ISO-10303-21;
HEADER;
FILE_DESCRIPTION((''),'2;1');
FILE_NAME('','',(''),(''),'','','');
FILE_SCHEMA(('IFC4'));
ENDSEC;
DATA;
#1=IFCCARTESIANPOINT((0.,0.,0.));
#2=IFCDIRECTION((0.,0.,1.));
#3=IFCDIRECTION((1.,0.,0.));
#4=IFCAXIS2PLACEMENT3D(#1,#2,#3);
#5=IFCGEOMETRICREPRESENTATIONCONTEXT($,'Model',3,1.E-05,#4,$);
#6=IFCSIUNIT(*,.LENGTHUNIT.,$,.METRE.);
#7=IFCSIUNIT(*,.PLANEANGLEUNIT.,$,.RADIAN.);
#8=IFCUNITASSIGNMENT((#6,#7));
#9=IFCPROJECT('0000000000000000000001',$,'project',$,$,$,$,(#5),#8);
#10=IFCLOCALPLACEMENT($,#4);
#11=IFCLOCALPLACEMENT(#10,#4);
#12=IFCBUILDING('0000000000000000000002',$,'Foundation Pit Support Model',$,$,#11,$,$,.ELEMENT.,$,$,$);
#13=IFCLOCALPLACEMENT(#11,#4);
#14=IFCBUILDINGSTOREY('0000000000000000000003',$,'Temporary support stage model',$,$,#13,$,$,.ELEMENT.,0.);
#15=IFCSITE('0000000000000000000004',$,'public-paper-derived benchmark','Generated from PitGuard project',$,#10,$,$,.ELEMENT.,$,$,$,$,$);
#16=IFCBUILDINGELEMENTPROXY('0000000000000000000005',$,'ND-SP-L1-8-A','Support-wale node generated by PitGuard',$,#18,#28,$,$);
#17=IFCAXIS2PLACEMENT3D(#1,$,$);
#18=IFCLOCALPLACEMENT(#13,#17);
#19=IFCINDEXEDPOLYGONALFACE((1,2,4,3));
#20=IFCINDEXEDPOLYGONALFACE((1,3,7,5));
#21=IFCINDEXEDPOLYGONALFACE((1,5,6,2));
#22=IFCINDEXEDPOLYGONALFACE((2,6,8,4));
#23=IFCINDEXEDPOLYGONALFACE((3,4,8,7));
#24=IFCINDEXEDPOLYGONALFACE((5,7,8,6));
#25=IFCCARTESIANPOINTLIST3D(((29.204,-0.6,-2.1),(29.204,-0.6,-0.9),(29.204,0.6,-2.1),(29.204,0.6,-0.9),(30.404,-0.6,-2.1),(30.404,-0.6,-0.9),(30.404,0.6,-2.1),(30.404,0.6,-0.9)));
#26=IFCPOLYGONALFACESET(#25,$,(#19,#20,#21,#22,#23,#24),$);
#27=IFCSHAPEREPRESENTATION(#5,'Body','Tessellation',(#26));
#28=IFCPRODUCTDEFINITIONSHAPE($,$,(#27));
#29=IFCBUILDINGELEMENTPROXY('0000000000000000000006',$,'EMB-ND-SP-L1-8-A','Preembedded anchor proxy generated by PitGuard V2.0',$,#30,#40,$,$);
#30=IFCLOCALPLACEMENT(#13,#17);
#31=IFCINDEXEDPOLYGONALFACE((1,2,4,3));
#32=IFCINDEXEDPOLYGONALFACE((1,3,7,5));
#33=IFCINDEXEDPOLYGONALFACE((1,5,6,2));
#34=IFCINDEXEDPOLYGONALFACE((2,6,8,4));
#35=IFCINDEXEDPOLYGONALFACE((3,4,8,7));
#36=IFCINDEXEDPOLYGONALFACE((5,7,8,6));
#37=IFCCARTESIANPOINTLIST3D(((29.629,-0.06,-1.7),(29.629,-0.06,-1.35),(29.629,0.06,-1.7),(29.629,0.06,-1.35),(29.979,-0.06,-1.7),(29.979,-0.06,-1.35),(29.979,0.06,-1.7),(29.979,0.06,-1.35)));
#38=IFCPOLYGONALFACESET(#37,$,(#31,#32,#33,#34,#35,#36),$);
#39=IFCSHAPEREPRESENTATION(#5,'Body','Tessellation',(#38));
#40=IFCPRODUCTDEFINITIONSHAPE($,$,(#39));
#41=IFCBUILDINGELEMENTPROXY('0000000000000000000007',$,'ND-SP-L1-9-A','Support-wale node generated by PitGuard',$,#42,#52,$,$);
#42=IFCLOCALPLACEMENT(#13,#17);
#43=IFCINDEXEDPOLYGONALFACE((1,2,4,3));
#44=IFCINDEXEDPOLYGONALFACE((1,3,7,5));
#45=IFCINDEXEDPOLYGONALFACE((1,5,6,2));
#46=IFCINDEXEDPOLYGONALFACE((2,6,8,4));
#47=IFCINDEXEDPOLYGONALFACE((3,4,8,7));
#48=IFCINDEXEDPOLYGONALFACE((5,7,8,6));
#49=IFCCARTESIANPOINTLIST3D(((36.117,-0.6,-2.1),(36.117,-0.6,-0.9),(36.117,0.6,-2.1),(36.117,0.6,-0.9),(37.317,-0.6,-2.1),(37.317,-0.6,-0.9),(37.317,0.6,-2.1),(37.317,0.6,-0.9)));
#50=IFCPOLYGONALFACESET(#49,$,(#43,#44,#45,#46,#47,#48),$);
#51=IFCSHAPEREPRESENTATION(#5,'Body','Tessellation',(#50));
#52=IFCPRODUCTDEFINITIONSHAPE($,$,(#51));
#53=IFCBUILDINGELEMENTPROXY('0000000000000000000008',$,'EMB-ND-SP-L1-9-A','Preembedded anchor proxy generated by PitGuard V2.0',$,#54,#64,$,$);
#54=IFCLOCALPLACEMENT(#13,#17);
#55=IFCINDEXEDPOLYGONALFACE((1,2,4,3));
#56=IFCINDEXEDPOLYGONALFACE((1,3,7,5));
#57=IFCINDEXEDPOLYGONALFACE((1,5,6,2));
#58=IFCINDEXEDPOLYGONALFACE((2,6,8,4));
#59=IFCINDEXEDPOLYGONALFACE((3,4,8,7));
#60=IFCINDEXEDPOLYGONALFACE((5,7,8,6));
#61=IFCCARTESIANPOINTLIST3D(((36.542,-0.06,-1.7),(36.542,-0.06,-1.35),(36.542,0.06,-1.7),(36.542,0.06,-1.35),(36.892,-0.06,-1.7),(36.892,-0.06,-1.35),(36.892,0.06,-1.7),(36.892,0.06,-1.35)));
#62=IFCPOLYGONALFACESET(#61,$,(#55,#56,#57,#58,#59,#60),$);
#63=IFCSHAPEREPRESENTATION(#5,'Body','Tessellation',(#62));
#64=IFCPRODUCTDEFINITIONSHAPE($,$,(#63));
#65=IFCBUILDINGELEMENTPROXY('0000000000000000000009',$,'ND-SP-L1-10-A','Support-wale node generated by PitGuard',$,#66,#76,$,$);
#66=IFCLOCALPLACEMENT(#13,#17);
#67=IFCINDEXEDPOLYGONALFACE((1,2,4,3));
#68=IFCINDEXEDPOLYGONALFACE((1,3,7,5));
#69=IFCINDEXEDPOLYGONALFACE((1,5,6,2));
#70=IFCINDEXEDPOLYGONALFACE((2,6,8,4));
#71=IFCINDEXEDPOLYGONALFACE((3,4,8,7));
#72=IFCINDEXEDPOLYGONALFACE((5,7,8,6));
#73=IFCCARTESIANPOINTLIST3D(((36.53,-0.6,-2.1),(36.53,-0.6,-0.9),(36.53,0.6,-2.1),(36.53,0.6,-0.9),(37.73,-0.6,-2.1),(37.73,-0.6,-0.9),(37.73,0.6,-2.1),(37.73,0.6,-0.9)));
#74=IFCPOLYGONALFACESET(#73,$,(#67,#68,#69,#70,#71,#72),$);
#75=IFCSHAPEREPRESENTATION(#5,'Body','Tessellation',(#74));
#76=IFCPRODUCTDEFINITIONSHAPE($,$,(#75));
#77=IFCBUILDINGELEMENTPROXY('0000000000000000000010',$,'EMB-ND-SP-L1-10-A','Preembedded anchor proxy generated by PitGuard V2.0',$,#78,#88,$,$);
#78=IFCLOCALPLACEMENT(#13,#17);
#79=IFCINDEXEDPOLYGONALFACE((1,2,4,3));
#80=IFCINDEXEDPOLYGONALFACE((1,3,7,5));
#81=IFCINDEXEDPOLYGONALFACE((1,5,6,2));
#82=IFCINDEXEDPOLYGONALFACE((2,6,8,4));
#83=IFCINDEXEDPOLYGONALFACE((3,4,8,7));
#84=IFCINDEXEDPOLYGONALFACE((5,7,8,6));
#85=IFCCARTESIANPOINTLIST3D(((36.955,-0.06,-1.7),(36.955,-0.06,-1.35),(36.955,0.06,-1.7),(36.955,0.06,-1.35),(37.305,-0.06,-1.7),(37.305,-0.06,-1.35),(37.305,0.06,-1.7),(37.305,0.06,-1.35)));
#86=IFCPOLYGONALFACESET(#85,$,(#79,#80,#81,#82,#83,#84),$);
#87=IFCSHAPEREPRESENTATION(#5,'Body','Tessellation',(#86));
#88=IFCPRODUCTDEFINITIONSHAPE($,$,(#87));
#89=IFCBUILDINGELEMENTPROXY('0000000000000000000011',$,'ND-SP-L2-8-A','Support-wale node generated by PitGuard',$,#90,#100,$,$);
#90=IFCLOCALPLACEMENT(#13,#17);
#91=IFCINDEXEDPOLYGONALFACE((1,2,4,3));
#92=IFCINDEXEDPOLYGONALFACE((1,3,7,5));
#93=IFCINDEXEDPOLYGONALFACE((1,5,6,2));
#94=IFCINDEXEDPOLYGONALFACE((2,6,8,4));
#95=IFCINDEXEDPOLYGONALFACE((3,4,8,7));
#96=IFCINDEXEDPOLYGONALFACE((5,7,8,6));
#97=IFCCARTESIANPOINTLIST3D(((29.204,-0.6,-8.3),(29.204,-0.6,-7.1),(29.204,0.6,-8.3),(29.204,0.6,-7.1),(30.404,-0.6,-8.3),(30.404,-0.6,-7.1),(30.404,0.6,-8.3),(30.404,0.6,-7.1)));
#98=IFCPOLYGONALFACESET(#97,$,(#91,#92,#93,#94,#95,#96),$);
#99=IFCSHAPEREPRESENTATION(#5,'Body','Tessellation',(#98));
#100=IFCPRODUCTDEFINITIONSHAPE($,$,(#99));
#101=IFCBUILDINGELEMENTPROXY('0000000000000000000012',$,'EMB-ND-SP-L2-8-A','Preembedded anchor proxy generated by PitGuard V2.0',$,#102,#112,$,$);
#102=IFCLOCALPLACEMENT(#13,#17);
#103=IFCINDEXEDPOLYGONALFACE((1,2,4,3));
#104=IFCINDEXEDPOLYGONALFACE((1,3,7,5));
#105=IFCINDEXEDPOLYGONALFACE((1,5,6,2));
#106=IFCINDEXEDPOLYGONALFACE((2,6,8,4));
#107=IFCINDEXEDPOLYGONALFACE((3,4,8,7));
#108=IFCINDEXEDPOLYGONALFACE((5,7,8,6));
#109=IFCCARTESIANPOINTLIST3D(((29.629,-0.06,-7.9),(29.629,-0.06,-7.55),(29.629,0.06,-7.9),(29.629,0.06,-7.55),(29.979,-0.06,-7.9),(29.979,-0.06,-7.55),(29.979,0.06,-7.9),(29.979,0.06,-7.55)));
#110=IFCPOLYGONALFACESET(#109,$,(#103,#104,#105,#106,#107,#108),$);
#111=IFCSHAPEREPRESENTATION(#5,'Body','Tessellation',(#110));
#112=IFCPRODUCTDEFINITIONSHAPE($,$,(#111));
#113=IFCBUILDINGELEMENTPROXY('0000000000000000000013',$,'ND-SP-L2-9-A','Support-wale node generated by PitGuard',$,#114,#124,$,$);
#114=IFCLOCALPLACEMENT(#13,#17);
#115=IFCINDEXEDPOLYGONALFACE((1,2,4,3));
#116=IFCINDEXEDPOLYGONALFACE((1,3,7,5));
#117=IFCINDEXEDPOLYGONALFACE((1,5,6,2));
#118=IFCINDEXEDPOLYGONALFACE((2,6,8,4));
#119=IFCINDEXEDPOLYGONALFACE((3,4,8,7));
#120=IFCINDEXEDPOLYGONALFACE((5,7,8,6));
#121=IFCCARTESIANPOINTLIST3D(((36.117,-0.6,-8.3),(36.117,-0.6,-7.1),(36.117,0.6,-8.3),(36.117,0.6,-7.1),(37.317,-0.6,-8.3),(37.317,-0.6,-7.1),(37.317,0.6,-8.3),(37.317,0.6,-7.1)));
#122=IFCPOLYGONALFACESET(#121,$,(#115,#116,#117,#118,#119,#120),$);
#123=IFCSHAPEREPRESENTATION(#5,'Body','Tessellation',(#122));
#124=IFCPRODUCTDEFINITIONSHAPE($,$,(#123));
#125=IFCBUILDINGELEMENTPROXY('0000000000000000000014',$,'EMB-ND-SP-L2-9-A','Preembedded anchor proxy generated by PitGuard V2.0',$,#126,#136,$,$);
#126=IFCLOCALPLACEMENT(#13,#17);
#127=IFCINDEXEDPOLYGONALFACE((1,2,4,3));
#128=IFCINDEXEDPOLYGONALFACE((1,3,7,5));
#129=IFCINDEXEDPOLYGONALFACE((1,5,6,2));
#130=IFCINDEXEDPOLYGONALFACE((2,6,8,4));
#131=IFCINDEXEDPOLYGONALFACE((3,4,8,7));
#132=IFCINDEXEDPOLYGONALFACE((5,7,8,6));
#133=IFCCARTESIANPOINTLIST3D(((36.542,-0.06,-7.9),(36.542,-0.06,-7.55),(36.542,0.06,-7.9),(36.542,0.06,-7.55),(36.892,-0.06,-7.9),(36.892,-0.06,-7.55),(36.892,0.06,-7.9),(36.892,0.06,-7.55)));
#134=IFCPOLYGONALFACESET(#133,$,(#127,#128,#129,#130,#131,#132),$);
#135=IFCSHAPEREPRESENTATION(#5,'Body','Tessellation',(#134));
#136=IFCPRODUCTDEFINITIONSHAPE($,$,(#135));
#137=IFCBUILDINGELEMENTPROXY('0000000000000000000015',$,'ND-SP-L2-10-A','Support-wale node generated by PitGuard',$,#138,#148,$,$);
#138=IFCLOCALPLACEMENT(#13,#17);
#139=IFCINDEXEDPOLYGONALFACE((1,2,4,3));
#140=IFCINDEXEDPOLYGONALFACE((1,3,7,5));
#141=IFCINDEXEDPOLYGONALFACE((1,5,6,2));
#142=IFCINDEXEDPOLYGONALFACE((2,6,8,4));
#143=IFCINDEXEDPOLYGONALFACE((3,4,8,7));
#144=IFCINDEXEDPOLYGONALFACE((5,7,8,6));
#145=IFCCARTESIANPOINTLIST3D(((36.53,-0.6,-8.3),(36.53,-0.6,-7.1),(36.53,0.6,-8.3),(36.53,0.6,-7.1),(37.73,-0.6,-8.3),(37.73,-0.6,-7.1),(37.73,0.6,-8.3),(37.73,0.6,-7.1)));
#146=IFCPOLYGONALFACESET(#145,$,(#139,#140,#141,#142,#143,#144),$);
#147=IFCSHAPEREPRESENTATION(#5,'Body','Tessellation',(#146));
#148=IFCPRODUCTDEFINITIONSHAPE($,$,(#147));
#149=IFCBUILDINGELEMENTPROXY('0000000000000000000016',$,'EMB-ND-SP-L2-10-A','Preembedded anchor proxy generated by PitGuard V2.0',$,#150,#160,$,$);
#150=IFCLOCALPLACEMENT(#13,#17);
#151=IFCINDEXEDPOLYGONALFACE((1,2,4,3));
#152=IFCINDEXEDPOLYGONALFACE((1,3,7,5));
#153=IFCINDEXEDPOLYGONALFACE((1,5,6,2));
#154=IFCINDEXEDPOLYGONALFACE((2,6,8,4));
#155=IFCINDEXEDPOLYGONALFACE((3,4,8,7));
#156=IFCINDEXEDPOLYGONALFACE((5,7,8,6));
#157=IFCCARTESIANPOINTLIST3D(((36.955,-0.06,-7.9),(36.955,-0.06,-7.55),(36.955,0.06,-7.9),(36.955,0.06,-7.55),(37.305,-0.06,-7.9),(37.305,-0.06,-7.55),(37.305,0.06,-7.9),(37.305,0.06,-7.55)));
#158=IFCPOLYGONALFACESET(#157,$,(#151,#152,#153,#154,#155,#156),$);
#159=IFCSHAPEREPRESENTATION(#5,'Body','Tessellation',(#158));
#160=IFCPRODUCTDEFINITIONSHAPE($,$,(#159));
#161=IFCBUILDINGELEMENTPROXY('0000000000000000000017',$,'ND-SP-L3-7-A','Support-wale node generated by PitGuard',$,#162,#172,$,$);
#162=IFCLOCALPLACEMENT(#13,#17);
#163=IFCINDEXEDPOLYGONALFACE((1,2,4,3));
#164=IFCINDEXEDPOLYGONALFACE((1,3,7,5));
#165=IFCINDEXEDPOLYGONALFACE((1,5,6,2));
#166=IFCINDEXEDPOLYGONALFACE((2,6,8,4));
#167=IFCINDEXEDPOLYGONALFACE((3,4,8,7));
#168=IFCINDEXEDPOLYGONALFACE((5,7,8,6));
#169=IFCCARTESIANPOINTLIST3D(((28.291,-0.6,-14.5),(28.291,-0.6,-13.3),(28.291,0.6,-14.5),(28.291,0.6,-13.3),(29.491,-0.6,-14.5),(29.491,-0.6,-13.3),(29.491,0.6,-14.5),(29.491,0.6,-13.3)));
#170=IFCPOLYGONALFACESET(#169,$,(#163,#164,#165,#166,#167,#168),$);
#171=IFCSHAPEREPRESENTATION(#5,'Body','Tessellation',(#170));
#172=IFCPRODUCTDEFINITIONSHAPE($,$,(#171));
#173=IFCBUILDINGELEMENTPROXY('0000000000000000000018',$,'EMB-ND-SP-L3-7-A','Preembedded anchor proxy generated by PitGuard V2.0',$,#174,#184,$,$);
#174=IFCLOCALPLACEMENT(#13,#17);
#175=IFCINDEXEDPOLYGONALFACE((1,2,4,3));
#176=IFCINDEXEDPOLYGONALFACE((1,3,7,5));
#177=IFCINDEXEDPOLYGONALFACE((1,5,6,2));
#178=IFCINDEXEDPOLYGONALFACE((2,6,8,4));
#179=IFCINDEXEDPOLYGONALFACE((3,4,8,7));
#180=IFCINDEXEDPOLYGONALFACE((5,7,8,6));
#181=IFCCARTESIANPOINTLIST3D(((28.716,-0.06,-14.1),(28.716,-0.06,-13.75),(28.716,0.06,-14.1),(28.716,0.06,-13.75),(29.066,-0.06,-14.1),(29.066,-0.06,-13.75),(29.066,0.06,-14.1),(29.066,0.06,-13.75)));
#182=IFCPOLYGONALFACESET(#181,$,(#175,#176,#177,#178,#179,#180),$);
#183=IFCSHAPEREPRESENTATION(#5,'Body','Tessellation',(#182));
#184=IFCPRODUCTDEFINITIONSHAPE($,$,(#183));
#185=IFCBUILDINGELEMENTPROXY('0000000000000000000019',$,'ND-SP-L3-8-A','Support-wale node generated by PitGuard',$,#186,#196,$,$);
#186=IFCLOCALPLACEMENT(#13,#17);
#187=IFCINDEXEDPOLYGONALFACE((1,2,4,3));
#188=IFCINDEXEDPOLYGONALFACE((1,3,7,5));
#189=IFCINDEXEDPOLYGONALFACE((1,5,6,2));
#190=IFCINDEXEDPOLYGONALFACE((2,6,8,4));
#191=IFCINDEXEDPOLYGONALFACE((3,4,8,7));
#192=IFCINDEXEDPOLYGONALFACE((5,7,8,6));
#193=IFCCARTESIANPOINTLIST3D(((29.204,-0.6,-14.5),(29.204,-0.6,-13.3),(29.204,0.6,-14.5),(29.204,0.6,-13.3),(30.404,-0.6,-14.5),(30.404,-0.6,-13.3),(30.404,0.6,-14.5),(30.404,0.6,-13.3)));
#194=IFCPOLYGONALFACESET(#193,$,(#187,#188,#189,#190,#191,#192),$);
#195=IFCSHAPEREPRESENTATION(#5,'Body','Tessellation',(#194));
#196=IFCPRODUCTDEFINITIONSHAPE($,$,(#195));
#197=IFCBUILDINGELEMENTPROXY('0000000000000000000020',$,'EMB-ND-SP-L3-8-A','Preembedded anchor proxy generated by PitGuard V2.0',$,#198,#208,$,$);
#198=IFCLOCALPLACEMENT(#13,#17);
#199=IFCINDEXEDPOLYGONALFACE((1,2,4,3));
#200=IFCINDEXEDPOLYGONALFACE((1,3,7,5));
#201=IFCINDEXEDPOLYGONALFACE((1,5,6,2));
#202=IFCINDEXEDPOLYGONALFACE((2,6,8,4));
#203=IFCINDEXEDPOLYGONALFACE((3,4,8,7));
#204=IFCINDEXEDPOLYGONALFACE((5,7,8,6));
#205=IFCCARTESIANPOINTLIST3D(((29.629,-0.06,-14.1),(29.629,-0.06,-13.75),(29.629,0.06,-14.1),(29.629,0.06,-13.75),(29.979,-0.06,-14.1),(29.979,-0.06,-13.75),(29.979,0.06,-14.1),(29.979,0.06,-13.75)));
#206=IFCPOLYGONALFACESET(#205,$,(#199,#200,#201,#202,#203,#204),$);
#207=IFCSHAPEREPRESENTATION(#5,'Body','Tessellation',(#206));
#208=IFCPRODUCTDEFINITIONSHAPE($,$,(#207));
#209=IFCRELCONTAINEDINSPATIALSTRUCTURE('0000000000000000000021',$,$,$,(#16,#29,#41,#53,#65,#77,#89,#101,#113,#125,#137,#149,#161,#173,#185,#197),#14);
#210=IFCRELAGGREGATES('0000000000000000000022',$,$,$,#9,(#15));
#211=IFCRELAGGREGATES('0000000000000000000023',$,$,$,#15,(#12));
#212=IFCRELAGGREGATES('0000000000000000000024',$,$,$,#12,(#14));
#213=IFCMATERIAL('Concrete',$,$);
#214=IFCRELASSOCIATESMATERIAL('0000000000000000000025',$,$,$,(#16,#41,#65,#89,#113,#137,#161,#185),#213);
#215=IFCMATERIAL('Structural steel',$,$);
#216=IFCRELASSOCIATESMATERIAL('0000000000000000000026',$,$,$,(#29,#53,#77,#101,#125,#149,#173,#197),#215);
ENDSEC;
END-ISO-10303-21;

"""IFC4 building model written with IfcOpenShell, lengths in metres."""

from ifc_helpers import new_model, si_unit, frame, origin_with_axes, origin_2d, place, context, project, spatial, rectangle, extrude, material, element, save


model = new_model("IFC4")

# Units and contexts
model_context = context("Model", 3, precision=1e-05, world=origin_with_axes())
ifc_project = project(units=[si_unit("LENGTHUNIT", "METRE"), si_unit("PLANEANGLEUNIT", "RADIAN")], contexts=[model_context])

# Site, building, storey
site_placement = place(None, origin_with_axes())
site = spatial("IfcSite", under=ifc_project, at=site_placement, Name="public-paper-derived benchmark", Description="Generated from PitGuard project", CompositionType="ELEMENT")
building_placement = place(site_placement, origin_with_axes())
building = spatial("IfcBuilding", under=site, at=building_placement, Name="Foundation Pit Support Model", CompositionType="ELEMENT")
storey_placement = place(building_placement, origin_with_axes())
storey = spatial("IfcBuildingStorey", under=building, at=storey_placement, Name="Temporary support stage model", CompositionType="ELEMENT", Elevation=0.0)

# Shared definitions
ifc_material_1 = material(Name="Structural steel")

# Shared definitions
ifc_material_2 = material(Name="Concrete")

# Building element proxies
proxy_1_placement = place(storey_placement, frame((29.804, 0.0, -2.1), z_axis=(0.0, 0.0, 1.0), x_axis=(1.0, 0.0, 0.0)))
element("IfcBuildingElementProxy", 1, at=proxy_1_placement, inside=storey, material=ifc_material_2, Name="ND-SP-L1-8-A", Description="Support-wale node generated by PitGuard", context=model_context, shape_type="SweptSolid", body=[
    extrude(rectangle(XDim=1.2, YDim=1.2, at=origin_2d()), origin_with_axes(), (0.0, 0.0, 1.0), 1.2),
])
proxy_2_placement = place(storey_placement, frame((29.804, 0.0, -1.7), z_axis=(0.0, 0.0, 1.0), x_axis=(1.0, 0.0, 0.0)))
element("IfcBuildingElementProxy", 2, at=proxy_2_placement, inside=storey, material=ifc_material_1, Name="EMB-ND-SP-L1-8-A", Description="Preembedded anchor proxy generated by PitGuard V2.0", context=model_context, shape_type="SweptSolid", body=[
    extrude(rectangle(XDim=0.35, YDim=0.12, at=origin_2d()), origin_with_axes(), (0.0, 0.0, 1.0), 0.35),
])
proxy_3_placement = place(storey_placement, frame((36.717, 0.0, -2.1), z_axis=(0.0, 0.0, 1.0), x_axis=(1.0, 0.0, 0.0)))
element("IfcBuildingElementProxy", 3, at=proxy_3_placement, inside=storey, material=ifc_material_2, Name="ND-SP-L1-9-A", Description="Support-wale node generated by PitGuard", context=model_context, shape_type="SweptSolid", body=[
    extrude(rectangle(XDim=1.2, YDim=1.2, at=origin_2d()), origin_with_axes(), (0.0, 0.0, 1.0), 1.2),
])
proxy_4_placement = place(storey_placement, frame((36.717, 0.0, -1.7), z_axis=(0.0, 0.0, 1.0), x_axis=(1.0, 0.0, 0.0)))
element("IfcBuildingElementProxy", 4, at=proxy_4_placement, inside=storey, material=ifc_material_1, Name="EMB-ND-SP-L1-9-A", Description="Preembedded anchor proxy generated by PitGuard V2.0", context=model_context, shape_type="SweptSolid", body=[
    extrude(rectangle(XDim=0.35, YDim=0.12, at=origin_2d()), origin_with_axes(), (0.0, 0.0, 1.0), 0.35),
])
proxy_5_placement = place(storey_placement, frame((37.13, 0.0, -2.1), z_axis=(0.0, 0.0, 1.0), x_axis=(1.0, 0.0, 0.0)))
element("IfcBuildingElementProxy", 5, at=proxy_5_placement, inside=storey, material=ifc_material_2, Name="ND-SP-L1-10-A", Description="Support-wale node generated by PitGuard", context=model_context, shape_type="SweptSolid", body=[
    extrude(rectangle(XDim=1.2, YDim=1.2, at=origin_2d()), origin_with_axes(), (0.0, 0.0, 1.0), 1.2),
])
proxy_6_placement = place(storey_placement, frame((37.13, 0.0, -1.7), z_axis=(0.0, 0.0, 1.0), x_axis=(1.0, 0.0, 0.0)))
element("IfcBuildingElementProxy", 6, at=proxy_6_placement, inside=storey, material=ifc_material_1, Name="EMB-ND-SP-L1-10-A", Description="Preembedded anchor proxy generated by PitGuard V2.0", context=model_context, shape_type="SweptSolid", body=[
    extrude(rectangle(XDim=0.35, YDim=0.12, at=origin_2d()), origin_with_axes(), (0.0, 0.0, 1.0), 0.35),
])
proxy_7_placement = place(storey_placement, frame((29.804, 0.0, -8.3), z_axis=(0.0, 0.0, 1.0), x_axis=(1.0, 0.0, 0.0)))
element("IfcBuildingElementProxy", 7, at=proxy_7_placement, inside=storey, material=ifc_material_2, Name="ND-SP-L2-8-A", Description="Support-wale node generated by PitGuard", context=model_context, shape_type="SweptSolid", body=[
    extrude(rectangle(XDim=1.2, YDim=1.2, at=origin_2d()), origin_with_axes(), (0.0, 0.0, 1.0), 1.2),
])
proxy_8_placement = place(storey_placement, frame((29.804, 0.0, -7.9), z_axis=(0.0, 0.0, 1.0), x_axis=(1.0, 0.0, 0.0)))
element("IfcBuildingElementProxy", 8, at=proxy_8_placement, inside=storey, material=ifc_material_1, Name="EMB-ND-SP-L2-8-A", Description="Preembedded anchor proxy generated by PitGuard V2.0", context=model_context, shape_type="SweptSolid", body=[
    extrude(rectangle(XDim=0.35, YDim=0.12, at=origin_2d()), origin_with_axes(), (0.0, 0.0, 1.0), 0.35),
])
proxy_9_placement = place(storey_placement, frame((36.717, 0.0, -8.3), z_axis=(0.0, 0.0, 1.0), x_axis=(1.0, 0.0, 0.0)))
element("IfcBuildingElementProxy", 9, at=proxy_9_placement, inside=storey, material=ifc_material_2, Name="ND-SP-L2-9-A", Description="Support-wale node generated by PitGuard", context=model_context, shape_type="SweptSolid", body=[
    extrude(rectangle(XDim=1.2, YDim=1.2, at=origin_2d()), origin_with_axes(), (0.0, 0.0, 1.0), 1.2),
])
proxy_10_placement = place(storey_placement, frame((36.717, 0.0, -7.9), z_axis=(0.0, 0.0, 1.0), x_axis=(1.0, 0.0, 0.0)))
element("IfcBuildingElementProxy", 10, at=proxy_10_placement, inside=storey, material=ifc_material_1, Name="EMB-ND-SP-L2-9-A", Description="Preembedded anchor proxy generated by PitGuard V2.0", context=model_context, shape_type="SweptSolid", body=[
    extrude(rectangle(XDim=0.35, YDim=0.12, at=origin_2d()), origin_with_axes(), (0.0, 0.0, 1.0), 0.35),
])
proxy_11_placement = place(storey_placement, frame((37.13, 0.0, -8.3), z_axis=(0.0, 0.0, 1.0), x_axis=(1.0, 0.0, 0.0)))
element("IfcBuildingElementProxy", 11, at=proxy_11_placement, inside=storey, material=ifc_material_2, Name="ND-SP-L2-10-A", Description="Support-wale node generated by PitGuard", context=model_context, shape_type="SweptSolid", body=[
    extrude(rectangle(XDim=1.2, YDim=1.2, at=origin_2d()), origin_with_axes(), (0.0, 0.0, 1.0), 1.2),
])
proxy_12_placement = place(storey_placement, frame((37.13, 0.0, -7.9), z_axis=(0.0, 0.0, 1.0), x_axis=(1.0, 0.0, 0.0)))
element("IfcBuildingElementProxy", 12, at=proxy_12_placement, inside=storey, material=ifc_material_1, Name="EMB-ND-SP-L2-10-A", Description="Preembedded anchor proxy generated by PitGuard V2.0", context=model_context, shape_type="SweptSolid", body=[
    extrude(rectangle(XDim=0.35, YDim=0.12, at=origin_2d()), origin_with_axes(), (0.0, 0.0, 1.0), 0.35),
])
proxy_13_placement = place(storey_placement, frame((28.891, 0.0, -14.5), z_axis=(0.0, 0.0, 1.0), x_axis=(1.0, 0.0, 0.0)))
element("IfcBuildingElementProxy", 13, at=proxy_13_placement, inside=storey, material=ifc_material_2, Name="ND-SP-L3-7-A", Description="Support-wale node generated by PitGuard", context=model_context, shape_type="SweptSolid", body=[
    extrude(rectangle(XDim=1.2, YDim=1.2, at=origin_2d()), origin_with_axes(), (0.0, 0.0, 1.0), 1.2),
])
proxy_14_placement = place(storey_placement, frame((28.891, 0.0, -14.1), z_axis=(0.0, 0.0, 1.0), x_axis=(1.0, 0.0, 0.0)))
element("IfcBuildingElementProxy", 14, at=proxy_14_placement, inside=storey, material=ifc_material_1, Name="EMB-ND-SP-L3-7-A", Description="Preembedded anchor proxy generated by PitGuard V2.0", context=model_context, shape_type="SweptSolid", body=[
    extrude(rectangle(XDim=0.35, YDim=0.12, at=origin_2d()), origin_with_axes(), (0.0, 0.0, 1.0), 0.35),
])
proxy_15_placement = place(storey_placement, frame((29.804, 0.0, -14.5), z_axis=(0.0, 0.0, 1.0), x_axis=(1.0, 0.0, 0.0)))
element("IfcBuildingElementProxy", 15, at=proxy_15_placement, inside=storey, material=ifc_material_2, Name="ND-SP-L3-8-A", Description="Support-wale node generated by PitGuard", context=model_context, shape_type="SweptSolid", body=[
    extrude(rectangle(XDim=1.2, YDim=1.2, at=origin_2d()), origin_with_axes(), (0.0, 0.0, 1.0), 1.2),
])
proxy_16_placement = place(storey_placement, frame((29.804, 0.0, -14.1), z_axis=(0.0, 0.0, 1.0), x_axis=(1.0, 0.0, 0.0)))
element("IfcBuildingElementProxy", 16, at=proxy_16_placement, inside=storey, material=ifc_material_1, Name="EMB-ND-SP-L3-8-A", Description="Preembedded anchor proxy generated by PitGuard V2.0", context=model_context, shape_type="SweptSolid", body=[
    extrude(rectangle(XDim=0.35, YDim=0.12, at=origin_2d()), origin_with_axes(), (0.0, 0.0, 1.0), 0.35),
])

save(model, "model.ifc")
